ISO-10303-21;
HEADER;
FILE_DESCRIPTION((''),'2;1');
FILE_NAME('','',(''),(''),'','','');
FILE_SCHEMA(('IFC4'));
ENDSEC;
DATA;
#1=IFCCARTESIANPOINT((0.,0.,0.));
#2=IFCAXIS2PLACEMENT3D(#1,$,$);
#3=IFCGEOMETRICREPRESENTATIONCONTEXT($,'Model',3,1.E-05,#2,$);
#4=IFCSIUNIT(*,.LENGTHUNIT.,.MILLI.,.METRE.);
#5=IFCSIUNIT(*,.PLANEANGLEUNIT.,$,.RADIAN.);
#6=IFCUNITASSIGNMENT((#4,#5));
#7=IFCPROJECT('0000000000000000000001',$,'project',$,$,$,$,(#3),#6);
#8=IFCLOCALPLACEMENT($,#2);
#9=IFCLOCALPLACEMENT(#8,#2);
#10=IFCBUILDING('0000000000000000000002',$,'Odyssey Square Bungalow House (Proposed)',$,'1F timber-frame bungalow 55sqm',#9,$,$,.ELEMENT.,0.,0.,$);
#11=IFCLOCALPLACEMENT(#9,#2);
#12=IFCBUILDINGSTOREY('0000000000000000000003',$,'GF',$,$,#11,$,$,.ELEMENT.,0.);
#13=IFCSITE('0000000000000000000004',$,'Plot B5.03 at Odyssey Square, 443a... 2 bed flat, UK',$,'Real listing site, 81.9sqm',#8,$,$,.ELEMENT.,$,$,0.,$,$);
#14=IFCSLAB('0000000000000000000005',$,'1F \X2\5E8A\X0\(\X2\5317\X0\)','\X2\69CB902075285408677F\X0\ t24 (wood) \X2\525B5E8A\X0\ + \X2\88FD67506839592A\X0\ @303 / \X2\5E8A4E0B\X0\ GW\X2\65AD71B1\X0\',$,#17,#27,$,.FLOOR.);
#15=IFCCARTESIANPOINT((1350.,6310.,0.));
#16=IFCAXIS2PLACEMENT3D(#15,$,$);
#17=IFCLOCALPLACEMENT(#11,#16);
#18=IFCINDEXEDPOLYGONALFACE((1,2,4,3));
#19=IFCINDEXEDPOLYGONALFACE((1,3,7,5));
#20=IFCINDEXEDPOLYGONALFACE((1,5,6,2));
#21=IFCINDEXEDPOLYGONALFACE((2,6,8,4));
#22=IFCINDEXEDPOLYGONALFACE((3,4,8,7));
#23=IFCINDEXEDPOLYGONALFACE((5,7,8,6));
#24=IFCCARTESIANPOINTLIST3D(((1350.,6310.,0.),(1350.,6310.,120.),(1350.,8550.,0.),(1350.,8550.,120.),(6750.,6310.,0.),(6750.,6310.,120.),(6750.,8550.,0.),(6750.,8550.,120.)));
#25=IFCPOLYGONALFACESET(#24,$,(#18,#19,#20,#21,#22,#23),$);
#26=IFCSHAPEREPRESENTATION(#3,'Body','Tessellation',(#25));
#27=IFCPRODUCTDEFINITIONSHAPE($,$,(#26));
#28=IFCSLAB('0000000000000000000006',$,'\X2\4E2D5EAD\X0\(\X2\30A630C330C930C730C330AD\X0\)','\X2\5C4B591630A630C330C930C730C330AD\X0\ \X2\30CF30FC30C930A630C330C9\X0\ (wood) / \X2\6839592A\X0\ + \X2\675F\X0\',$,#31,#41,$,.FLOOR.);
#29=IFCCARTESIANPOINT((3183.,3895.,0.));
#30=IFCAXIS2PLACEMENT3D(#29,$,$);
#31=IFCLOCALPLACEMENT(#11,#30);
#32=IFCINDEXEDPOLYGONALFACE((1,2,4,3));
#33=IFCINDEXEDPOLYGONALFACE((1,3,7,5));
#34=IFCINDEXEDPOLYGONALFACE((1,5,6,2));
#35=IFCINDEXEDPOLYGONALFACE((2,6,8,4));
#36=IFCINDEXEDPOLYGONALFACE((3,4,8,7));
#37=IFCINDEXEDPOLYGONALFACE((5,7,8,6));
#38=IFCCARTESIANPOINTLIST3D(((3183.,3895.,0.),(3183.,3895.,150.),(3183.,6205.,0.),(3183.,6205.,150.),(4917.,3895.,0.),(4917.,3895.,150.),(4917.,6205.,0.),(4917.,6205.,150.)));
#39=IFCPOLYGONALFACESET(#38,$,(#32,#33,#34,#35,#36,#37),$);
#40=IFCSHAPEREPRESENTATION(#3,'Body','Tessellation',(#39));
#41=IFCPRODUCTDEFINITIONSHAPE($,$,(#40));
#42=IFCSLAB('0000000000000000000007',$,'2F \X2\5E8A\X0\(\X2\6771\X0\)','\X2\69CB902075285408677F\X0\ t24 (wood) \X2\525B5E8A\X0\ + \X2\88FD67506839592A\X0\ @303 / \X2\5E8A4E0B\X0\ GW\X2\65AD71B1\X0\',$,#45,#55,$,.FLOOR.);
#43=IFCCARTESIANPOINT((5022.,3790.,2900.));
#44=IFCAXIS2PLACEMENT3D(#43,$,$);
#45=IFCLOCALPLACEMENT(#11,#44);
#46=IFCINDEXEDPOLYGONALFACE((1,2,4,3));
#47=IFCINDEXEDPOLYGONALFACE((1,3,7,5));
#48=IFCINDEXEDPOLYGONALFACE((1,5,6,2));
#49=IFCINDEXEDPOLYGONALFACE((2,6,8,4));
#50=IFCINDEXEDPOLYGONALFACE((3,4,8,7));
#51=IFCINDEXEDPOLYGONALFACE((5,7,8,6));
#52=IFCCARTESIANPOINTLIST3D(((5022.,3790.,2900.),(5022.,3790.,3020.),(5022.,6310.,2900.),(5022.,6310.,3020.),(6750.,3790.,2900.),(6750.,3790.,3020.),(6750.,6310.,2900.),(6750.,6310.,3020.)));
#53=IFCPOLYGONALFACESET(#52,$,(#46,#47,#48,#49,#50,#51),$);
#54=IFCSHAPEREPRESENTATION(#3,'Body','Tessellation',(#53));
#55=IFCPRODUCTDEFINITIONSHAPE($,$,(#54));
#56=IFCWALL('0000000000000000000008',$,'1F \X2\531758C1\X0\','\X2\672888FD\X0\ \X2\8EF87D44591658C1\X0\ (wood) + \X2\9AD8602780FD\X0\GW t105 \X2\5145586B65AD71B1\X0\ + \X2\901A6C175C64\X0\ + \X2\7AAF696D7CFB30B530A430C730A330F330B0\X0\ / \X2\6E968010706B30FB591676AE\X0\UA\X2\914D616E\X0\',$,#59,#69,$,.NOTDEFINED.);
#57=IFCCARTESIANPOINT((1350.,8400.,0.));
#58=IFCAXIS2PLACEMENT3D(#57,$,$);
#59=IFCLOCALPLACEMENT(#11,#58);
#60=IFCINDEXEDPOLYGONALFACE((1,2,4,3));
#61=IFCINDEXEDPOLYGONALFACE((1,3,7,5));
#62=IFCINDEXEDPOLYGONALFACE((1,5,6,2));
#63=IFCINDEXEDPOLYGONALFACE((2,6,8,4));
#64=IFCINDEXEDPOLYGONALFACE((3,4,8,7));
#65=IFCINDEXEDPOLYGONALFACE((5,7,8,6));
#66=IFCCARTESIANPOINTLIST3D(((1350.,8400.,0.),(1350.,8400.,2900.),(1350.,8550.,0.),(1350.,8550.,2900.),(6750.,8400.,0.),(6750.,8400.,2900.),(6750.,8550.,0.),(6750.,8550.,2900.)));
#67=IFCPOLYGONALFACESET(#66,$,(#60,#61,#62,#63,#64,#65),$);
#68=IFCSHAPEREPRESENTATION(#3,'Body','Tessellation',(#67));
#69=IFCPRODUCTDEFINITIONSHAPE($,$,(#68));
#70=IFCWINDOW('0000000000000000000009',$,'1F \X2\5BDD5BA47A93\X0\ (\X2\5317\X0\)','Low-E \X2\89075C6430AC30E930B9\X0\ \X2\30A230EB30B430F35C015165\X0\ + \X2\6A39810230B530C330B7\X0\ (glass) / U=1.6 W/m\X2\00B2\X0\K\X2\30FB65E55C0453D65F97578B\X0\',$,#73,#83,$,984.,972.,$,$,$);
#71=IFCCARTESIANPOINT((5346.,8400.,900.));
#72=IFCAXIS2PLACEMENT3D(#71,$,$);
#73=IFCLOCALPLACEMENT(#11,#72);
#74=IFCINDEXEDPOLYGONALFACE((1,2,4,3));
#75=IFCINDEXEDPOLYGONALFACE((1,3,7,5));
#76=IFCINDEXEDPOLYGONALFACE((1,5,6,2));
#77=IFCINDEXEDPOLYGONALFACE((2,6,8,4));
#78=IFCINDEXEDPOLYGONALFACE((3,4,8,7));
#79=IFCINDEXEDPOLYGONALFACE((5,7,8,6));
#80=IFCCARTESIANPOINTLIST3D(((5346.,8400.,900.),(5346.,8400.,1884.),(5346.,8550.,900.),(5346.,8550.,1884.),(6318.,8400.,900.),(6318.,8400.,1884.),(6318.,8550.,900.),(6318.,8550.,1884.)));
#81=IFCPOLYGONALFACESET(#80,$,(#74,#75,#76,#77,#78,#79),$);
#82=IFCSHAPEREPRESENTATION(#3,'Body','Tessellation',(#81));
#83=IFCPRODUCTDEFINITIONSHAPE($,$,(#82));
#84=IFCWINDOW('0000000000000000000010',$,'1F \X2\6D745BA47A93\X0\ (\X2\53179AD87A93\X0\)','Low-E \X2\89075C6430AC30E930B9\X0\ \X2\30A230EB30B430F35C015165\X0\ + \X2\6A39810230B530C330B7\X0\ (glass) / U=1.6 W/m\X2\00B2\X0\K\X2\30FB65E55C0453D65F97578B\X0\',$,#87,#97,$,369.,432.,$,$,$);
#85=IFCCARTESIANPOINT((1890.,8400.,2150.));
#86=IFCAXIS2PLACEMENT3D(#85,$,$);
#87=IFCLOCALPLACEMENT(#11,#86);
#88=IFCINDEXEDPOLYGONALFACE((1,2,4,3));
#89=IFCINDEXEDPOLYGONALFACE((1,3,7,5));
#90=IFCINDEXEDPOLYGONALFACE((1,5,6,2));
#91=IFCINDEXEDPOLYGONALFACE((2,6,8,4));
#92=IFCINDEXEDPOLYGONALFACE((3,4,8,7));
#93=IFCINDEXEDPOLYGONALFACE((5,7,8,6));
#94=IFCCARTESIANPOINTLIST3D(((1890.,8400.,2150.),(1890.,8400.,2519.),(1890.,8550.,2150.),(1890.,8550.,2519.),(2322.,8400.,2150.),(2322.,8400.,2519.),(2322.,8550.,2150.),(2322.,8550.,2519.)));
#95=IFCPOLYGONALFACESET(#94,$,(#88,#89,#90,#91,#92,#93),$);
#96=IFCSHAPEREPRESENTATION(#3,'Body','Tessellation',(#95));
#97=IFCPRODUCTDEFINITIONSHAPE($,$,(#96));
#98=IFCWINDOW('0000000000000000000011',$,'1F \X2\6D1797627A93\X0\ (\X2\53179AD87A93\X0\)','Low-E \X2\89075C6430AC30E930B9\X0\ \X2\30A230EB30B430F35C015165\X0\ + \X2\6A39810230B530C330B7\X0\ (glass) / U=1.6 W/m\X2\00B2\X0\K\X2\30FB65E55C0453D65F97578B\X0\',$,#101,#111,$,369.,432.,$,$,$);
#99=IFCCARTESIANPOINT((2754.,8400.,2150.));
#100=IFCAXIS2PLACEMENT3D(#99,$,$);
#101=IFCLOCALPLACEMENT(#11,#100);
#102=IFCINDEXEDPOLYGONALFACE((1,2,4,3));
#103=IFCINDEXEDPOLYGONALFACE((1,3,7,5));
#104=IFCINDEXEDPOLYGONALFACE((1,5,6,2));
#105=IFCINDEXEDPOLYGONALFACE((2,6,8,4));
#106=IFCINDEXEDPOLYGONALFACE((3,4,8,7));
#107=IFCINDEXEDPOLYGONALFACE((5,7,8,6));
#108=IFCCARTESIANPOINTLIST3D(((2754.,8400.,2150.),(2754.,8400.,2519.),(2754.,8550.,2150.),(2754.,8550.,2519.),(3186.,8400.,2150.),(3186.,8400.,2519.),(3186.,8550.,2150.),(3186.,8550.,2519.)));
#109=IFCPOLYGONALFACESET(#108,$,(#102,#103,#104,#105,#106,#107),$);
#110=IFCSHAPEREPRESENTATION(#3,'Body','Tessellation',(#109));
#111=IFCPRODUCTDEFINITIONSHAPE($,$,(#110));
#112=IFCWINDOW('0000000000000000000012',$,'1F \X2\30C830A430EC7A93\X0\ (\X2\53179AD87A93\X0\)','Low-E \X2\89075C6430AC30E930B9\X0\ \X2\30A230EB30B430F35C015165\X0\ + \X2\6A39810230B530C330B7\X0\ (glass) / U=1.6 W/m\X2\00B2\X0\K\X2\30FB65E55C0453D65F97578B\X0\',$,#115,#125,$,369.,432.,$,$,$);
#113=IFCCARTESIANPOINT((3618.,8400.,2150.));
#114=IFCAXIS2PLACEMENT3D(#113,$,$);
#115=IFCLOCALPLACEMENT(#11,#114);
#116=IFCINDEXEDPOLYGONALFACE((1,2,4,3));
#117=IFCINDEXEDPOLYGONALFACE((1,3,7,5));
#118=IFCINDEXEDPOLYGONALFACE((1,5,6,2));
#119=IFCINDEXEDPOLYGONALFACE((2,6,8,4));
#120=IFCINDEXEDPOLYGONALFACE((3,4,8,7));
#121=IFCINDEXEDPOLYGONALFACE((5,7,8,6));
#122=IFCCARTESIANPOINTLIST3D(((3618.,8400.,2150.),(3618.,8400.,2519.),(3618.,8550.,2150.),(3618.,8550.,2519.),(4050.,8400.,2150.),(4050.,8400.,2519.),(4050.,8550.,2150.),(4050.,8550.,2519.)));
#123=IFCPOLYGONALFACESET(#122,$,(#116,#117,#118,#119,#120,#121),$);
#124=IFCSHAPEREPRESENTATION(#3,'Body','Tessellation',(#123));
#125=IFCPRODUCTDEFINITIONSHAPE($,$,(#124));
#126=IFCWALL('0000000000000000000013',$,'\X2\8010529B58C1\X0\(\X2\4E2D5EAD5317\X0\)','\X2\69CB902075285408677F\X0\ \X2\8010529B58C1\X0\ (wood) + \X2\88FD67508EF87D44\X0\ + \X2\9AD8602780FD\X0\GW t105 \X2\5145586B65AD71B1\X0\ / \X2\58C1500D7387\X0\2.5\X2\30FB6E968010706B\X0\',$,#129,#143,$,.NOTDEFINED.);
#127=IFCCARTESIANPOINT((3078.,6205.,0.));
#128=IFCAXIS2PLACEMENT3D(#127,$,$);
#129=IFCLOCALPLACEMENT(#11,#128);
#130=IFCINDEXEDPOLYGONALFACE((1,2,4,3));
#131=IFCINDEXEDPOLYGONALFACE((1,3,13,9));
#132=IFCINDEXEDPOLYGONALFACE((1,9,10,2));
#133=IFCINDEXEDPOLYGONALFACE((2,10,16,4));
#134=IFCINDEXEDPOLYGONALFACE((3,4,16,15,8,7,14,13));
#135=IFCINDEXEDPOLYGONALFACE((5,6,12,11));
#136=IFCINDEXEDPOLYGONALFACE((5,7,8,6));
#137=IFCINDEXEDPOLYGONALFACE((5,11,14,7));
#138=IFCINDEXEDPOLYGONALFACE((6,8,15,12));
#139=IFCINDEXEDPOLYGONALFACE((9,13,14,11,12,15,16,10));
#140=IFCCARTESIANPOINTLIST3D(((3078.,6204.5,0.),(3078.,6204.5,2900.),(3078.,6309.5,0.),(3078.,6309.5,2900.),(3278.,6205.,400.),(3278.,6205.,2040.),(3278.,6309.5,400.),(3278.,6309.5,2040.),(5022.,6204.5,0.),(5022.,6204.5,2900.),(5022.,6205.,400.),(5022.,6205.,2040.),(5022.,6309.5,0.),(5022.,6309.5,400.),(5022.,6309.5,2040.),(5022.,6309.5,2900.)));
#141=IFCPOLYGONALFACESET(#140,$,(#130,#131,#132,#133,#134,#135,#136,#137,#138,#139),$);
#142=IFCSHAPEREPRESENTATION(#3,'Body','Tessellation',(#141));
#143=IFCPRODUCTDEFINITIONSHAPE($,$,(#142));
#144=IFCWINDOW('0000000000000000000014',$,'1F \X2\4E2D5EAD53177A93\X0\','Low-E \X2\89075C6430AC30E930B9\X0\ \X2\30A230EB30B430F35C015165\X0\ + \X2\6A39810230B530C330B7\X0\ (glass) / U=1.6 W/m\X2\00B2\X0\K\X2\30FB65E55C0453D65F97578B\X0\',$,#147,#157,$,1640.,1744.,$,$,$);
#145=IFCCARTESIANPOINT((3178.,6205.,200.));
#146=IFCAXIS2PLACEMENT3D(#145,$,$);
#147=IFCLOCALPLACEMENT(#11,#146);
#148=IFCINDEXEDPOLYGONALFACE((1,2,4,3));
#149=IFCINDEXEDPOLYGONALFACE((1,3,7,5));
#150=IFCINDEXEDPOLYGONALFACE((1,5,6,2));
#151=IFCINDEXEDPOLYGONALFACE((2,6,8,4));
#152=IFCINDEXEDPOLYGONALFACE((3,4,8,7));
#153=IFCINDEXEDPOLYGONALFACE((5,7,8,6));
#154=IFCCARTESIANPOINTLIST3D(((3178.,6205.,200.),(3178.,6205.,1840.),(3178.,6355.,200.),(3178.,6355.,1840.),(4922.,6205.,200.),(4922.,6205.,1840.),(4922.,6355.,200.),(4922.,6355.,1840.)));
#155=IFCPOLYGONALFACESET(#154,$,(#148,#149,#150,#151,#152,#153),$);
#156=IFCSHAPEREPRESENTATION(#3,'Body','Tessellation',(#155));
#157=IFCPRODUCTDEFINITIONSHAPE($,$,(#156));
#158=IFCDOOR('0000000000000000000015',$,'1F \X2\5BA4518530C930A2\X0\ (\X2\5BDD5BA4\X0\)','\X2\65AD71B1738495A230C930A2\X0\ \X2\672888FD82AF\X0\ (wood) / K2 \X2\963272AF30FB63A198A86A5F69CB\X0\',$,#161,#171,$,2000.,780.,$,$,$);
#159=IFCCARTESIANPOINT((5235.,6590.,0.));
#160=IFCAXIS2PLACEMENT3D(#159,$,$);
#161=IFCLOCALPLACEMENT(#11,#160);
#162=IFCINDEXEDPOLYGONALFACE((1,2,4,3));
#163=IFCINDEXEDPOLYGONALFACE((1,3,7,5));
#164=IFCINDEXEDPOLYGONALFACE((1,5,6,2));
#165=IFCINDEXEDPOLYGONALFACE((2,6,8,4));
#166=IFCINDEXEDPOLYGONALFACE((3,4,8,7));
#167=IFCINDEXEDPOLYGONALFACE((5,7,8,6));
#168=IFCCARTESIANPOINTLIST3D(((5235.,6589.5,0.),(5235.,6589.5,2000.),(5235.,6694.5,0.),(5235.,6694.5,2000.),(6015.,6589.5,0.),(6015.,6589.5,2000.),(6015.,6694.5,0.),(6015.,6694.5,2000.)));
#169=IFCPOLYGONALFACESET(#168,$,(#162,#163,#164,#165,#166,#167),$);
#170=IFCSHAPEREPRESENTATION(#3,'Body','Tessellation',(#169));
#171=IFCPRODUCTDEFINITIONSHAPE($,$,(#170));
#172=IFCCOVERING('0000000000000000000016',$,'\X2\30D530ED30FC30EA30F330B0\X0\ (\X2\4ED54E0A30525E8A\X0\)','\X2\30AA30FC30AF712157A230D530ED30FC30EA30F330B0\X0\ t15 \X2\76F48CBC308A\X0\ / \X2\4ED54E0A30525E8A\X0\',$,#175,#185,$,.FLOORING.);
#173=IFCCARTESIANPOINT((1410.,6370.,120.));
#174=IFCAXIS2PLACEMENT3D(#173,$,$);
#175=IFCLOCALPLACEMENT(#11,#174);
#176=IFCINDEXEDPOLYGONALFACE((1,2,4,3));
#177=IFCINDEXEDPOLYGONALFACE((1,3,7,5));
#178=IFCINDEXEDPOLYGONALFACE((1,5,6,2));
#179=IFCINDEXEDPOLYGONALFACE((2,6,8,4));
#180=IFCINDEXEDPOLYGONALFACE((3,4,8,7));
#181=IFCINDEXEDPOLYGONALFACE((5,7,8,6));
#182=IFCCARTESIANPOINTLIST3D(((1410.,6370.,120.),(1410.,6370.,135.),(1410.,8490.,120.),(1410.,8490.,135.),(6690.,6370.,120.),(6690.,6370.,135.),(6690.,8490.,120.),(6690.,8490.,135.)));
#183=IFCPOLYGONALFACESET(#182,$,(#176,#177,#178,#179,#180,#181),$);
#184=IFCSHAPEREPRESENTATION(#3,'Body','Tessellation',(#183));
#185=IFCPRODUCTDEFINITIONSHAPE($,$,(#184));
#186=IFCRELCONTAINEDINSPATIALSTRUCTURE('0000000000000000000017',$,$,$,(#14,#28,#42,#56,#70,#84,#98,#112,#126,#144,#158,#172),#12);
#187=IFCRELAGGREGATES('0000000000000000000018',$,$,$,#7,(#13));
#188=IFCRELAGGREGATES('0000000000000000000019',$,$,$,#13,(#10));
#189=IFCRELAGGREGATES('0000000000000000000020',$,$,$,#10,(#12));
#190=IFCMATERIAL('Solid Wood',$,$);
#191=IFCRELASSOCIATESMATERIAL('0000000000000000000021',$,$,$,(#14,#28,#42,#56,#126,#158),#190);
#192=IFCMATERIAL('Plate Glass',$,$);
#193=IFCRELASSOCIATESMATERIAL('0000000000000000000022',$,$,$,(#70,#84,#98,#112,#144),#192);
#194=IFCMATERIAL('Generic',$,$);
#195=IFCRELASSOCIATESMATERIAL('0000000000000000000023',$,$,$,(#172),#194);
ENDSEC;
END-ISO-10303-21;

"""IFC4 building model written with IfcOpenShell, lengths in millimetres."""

from ifc_helpers import new_model, si_unit, frame, frame_2d, origin, place, context, project, spatial, rectangle, extrude, material, element, fill, save


model = new_model("IFC4")

# Units and contexts
model_context = context("Model", 3, precision=1e-05, world=origin())
ifc_project = project(units=[si_unit("LENGTHUNIT", "METRE", prefix="MILLI"), si_unit("PLANEANGLEUNIT", "RADIAN")], contexts=[model_context])

# Site, building, storey
site_placement = place(None, origin())
site = spatial("IfcSite", under=ifc_project, at=site_placement, Name="Plot B5.03 at Odyssey Square, 443a... 2 bed flat, UK", ObjectType="Real listing site, 81.9sqm", CompositionType="ELEMENT", RefElevation=0.0)
building_placement = place(site_placement, origin())
building = spatial("IfcBuilding", under=site, at=building_placement, Name="Odyssey Square Bungalow House (Proposed)", ObjectType="1F timber-frame bungalow 55sqm", CompositionType="ELEMENT", ElevationOfRefHeight=0.0, ElevationOfTerrain=0.0)
storey_placement = place(building_placement, origin())
storey = spatial("IfcBuildingStorey", under=building, at=storey_placement, Name="GF", CompositionType="ELEMENT", Elevation=0.0)

# Slabs
ifc_material_1 = material(Name="Solid Wood")
slab_1_placement = place(storey_placement, frame((1350.0, 6310.0, 0.0)))
element("IfcSlab", 1, at=slab_1_placement, inside=storey, material=ifc_material_1, Name="1F 床(北)", Description="構造用合板 t24 (wood) 剛床 + 製材根太 @303 / 床下 GW断熱", PredefinedType="FLOOR", context=model_context, shape_type="SweptSolid", body=[
    extrude(rectangle(XDim=5400.0, YDim=2240.0, at=frame_2d((2700.0, 1120.0))), frame((1350.0, 6310.0, 0.0)), (0.0, 0.0, 1.0), 120.0),
])
slab_2_placement = place(storey_placement, frame((3183.0, 3895.0, 0.0)))
element("IfcSlab", 2, at=slab_2_placement, inside=storey, material=ifc_material_1, Name="中庭(ウッドデッキ)", Description="屋外ウッドデッキ ハードウッド (wood) / 根太 + 束", PredefinedType="FLOOR", context=model_context, shape_type="SweptSolid", body=[
    extrude(rectangle(XDim=1734.0, YDim=2310.0, at=frame_2d((867.0, 1155.0))), frame((3183.0, 3895.0, 0.0)), (0.0, 0.0, 1.0), 150.0),
])
slab_3_placement = place(storey_placement, frame((5022.0, 3790.0, 2900.0)))
element("IfcSlab", 3, at=slab_3_placement, inside=storey, material=ifc_material_1, Name="2F 床(東)", Description="構造用合板 t24 (wood) 剛床 + 製材根太 @303 / 床下 GW断熱", PredefinedType="FLOOR", context=model_context, shape_type="SweptSolid", body=[
    extrude(rectangle(XDim=1728.0, YDim=2520.0, at=frame_2d((864.0, 1260.0))), frame((5022.0, 3790.0, 2900.0)), (0.0, 0.0, 1.0), 120.0),
])

# Wall, openings, windows
wall_1_placement = place(storey_placement, frame((1350.0, 8400.0, 0.0)))
wall_1 = element("IfcWall", 4, at=wall_1_placement, inside=storey, material=ifc_material_1, Name="1F 北壁", Description="木製 軸組外壁 (wood) + 高性能GW t105 充填断熱 + 通気層 + 窯業系サイディング / 準耐火・外皮UA配慮", PredefinedType="NOTDEFINED", context=model_context, shape_type="SweptSolid", body=[
    extrude(rectangle(XDim=5400.0, YDim=150.0, at=frame_2d((2700.0, 75.0))), frame((1350.0, 8400.0, 0.0)), (0.0, 0.0, 1.0), 2900.0),
])
opening_1_placement = place(storey_placement, frame((5346.0, 8400.0, 900.0)))
opening_1 = element("IfcOpeningElement", 5, at=opening_1_placement, cuts=wall_1, PredefinedType="NOTDEFINED", context=model_context, shape_type="SweptSolid", body=[
    extrude(rectangle(XDim=972.0, YDim=150.0, at=frame_2d((486.0, 75.0))), frame((5346.0, 8400.0, 900.0)), (0.0, 0.0, 1.0), 984.0),
])
opening_2_placement = place(storey_placement, frame((1890.0, 8400.0, 2150.0)))
opening_2 = element("IfcOpeningElement", 6, at=opening_2_placement, cuts=wall_1, PredefinedType="NOTDEFINED", context=model_context, shape_type="SweptSolid", body=[
    extrude(rectangle(XDim=432.0, YDim=150.0, at=frame_2d((216.0, 75.0))), frame((1890.0, 8400.0, 2150.0)), (0.0, 0.0, 1.0), 369.0),
])
opening_3_placement = place(storey_placement, frame((2754.0, 8400.0, 2150.0)))
opening_3 = element("IfcOpeningElement", 7, at=opening_3_placement, cuts=wall_1, PredefinedType="NOTDEFINED", context=model_context, shape_type="SweptSolid", body=[
    extrude(rectangle(XDim=432.0, YDim=150.0, at=frame_2d((216.0, 75.0))), frame((2754.0, 8400.0, 2150.0)), (0.0, 0.0, 1.0), 369.0),
])
opening_4_placement = place(storey_placement, frame((3618.0, 8400.0, 2150.0)))
opening_4 = element("IfcOpeningElement", 8, at=opening_4_placement, cuts=wall_1, PredefinedType="NOTDEFINED", context=model_context, shape_type="SweptSolid", body=[
    extrude(rectangle(XDim=432.0, YDim=150.0, at=frame_2d((216.0, 75.0))), frame((3618.0, 8400.0, 2150.0)), (0.0, 0.0, 1.0), 369.0),
])
ifc_material_2 = material(Name="Plate Glass")
window_1_placement = place(storey_placement, frame((5346.0, 8400.0, 900.0)))
window_1 = element("IfcWindow", 9, at=window_1_placement, inside=storey, material=ifc_material_2, Name="1F 寝室窓 (北)", Description="Low-E 複層ガラス アルゴン封入 + 樹脂サッシ (glass) / U=1.6 W/m²K・日射取得型", OverallHeight=984.0, OverallWidth=972.0, context=model_context, shape_type="SweptSolid", body=[
    extrude(rectangle(XDim=972.0, YDim=150.0, at=frame_2d((486.0, 75.0))), frame((5346.0, 8400.0, 900.0)), (0.0, 0.0, 1.0), 984.0),
])
fill(opening_1, window_1)
window_2_placement = place(storey_placement, frame((1890.0, 8400.0, 2150.0)))
window_2 = element("IfcWindow", 10, at=window_2_placement, inside=storey, material=ifc_material_2, Name="1F 浴室窓 (北高窓)", Description="Low-E 複層ガラス アルゴン封入 + 樹脂サッシ (glass) / U=1.6 W/m²K・日射取得型", OverallHeight=369.0, OverallWidth=432.0, context=model_context, shape_type="SweptSolid", body=[
    extrude(rectangle(XDim=432.0, YDim=150.0, at=frame_2d((216.0, 75.0))), frame((1890.0, 8400.0, 2150.0)), (0.0, 0.0, 1.0), 369.0),
])
fill(opening_2, window_2)
window_3_placement = place(storey_placement, frame((2754.0, 8400.0, 2150.0)))
window_3 = element("IfcWindow", 11, at=window_3_placement, inside=storey, material=ifc_material_2, Name="1F 洗面窓 (北高窓)", Description="Low-E 複層ガラス アルゴン封入 + 樹脂サッシ (glass) / U=1.6 W/m²K・日射取得型", OverallHeight=369.0, OverallWidth=432.0, context=model_context, shape_type="SweptSolid", body=[
    extrude(rectangle(XDim=432.0, YDim=150.0, at=frame_2d((216.0, 75.0))), frame((2754.0, 8400.0, 2150.0)), (0.0, 0.0, 1.0), 369.0),
])
fill(opening_3, window_3)
window_4_placement = place(storey_placement, frame((3618.0, 8400.0, 2150.0)))
window_4 = element("IfcWindow", 12, at=window_4_placement, inside=storey, material=ifc_material_2, Name="1F トイレ窓 (北高窓)", Description="Low-E 複層ガラス アルゴン封入 + 樹脂サッシ (glass) / U=1.6 W/m²K・日射取得型", OverallHeight=369.0, OverallWidth=432.0, context=model_context, shape_type="SweptSolid", body=[
    extrude(rectangle(XDim=432.0, YDim=150.0, at=frame_2d((216.0, 75.0))), frame((3618.0, 8400.0, 2150.0)), (0.0, 0.0, 1.0), 369.0),
])
fill(opening_4, window_4)

# Wall, opening, window
wall_2_placement = place(storey_placement, frame((3078.0, 6205.0, 0.0)))
wall_2 = element("IfcWall", 13, at=wall_2_placement, inside=storey, material=ifc_material_1, Name="耐力壁(中庭北)", Description="構造用合板 耐力壁 (wood) + 製材軸組 + 高性能GW t105 充填断熱 / 壁倍率2.5・準耐火", PredefinedType="NOTDEFINED", context=model_context, shape_type="SweptSolid", body=[
    extrude(rectangle(XDim=1944.0, YDim=105.0, at=frame_2d((972.0, 52.0))), frame((3078.0, 6205.0, 0.0)), (0.0, 0.0, 1.0), 2900.0),
])
opening_5_placement = place(storey_placement, frame((3178.0, 6205.0, 200.0)))
opening_5 = element("IfcOpeningElement", 14, at=opening_5_placement, cuts=wall_2, PredefinedType="NOTDEFINED", context=model_context, shape_type="SweptSolid", body=[
    extrude(rectangle(XDim=1744.0, YDim=150.0, at=frame_2d((872.0, 75.0))), frame((3178.0, 6205.0, 200.0)), (0.0, 0.0, 1.0), 1640.0),
])
window_5_placement = place(storey_placement, frame((3178.0, 6205.0, 200.0)))
window_5 = element("IfcWindow", 15, at=window_5_placement, inside=storey, material=ifc_material_2, Name="1F 中庭北窓", Description="Low-E 複層ガラス アルゴン封入 + 樹脂サッシ (glass) / U=1.6 W/m²K・日射取得型", OverallHeight=1640.0, OverallWidth=1744.0, context=model_context, shape_type="SweptSolid", body=[
    extrude(rectangle(XDim=1744.0, YDim=150.0, at=frame_2d((872.0, 75.0))), frame((3178.0, 6205.0, 200.0)), (0.0, 0.0, 1.0), 1640.0),
])
fill(opening_5, window_5)

# Door
door_1_placement = place(storey_placement, frame((5235.0, 6590.0, 0.0)))
element("IfcDoor", 16, at=door_1_placement, inside=storey, material=ifc_material_1, Name="1F 室内ドア (寝室)", Description="断熱玄関ドア 木製芯 (wood) / K2 防犯・採風機構", OverallHeight=2000.0, OverallWidth=780.0, context=model_context, shape_type="SweptSolid", body=[
    extrude(rectangle(XDim=780.0, YDim=105.0, at=frame_2d((390.0, 52.0))), frame((5235.0, 6590.0, 0.0)), (0.0, 0.0, 1.0), 2000.0),
])

# Covering
ifc_material_3 = material(Name="Generic")
covering_1_placement = place(storey_placement, frame((1410.0, 6370.0, 120.0)))
element("IfcCovering", 17, at=covering_1_placement, inside=storey, material=ifc_material_3, Name="フローリング (仕上げ床)", Description="オーク無垢フローリング t15 直貼り / 仕上げ床", PredefinedType="FLOORING", context=model_context, shape_type="SweptSolid", body=[
    extrude(rectangle(XDim=5280.0, YDim=2120.0, at=frame_2d((2640.0, 1060.0))), frame((1410.0, 6370.0, 120.0)), (0.0, 0.0, 1.0), 15.0),
])

save(model, "model.ifc")
